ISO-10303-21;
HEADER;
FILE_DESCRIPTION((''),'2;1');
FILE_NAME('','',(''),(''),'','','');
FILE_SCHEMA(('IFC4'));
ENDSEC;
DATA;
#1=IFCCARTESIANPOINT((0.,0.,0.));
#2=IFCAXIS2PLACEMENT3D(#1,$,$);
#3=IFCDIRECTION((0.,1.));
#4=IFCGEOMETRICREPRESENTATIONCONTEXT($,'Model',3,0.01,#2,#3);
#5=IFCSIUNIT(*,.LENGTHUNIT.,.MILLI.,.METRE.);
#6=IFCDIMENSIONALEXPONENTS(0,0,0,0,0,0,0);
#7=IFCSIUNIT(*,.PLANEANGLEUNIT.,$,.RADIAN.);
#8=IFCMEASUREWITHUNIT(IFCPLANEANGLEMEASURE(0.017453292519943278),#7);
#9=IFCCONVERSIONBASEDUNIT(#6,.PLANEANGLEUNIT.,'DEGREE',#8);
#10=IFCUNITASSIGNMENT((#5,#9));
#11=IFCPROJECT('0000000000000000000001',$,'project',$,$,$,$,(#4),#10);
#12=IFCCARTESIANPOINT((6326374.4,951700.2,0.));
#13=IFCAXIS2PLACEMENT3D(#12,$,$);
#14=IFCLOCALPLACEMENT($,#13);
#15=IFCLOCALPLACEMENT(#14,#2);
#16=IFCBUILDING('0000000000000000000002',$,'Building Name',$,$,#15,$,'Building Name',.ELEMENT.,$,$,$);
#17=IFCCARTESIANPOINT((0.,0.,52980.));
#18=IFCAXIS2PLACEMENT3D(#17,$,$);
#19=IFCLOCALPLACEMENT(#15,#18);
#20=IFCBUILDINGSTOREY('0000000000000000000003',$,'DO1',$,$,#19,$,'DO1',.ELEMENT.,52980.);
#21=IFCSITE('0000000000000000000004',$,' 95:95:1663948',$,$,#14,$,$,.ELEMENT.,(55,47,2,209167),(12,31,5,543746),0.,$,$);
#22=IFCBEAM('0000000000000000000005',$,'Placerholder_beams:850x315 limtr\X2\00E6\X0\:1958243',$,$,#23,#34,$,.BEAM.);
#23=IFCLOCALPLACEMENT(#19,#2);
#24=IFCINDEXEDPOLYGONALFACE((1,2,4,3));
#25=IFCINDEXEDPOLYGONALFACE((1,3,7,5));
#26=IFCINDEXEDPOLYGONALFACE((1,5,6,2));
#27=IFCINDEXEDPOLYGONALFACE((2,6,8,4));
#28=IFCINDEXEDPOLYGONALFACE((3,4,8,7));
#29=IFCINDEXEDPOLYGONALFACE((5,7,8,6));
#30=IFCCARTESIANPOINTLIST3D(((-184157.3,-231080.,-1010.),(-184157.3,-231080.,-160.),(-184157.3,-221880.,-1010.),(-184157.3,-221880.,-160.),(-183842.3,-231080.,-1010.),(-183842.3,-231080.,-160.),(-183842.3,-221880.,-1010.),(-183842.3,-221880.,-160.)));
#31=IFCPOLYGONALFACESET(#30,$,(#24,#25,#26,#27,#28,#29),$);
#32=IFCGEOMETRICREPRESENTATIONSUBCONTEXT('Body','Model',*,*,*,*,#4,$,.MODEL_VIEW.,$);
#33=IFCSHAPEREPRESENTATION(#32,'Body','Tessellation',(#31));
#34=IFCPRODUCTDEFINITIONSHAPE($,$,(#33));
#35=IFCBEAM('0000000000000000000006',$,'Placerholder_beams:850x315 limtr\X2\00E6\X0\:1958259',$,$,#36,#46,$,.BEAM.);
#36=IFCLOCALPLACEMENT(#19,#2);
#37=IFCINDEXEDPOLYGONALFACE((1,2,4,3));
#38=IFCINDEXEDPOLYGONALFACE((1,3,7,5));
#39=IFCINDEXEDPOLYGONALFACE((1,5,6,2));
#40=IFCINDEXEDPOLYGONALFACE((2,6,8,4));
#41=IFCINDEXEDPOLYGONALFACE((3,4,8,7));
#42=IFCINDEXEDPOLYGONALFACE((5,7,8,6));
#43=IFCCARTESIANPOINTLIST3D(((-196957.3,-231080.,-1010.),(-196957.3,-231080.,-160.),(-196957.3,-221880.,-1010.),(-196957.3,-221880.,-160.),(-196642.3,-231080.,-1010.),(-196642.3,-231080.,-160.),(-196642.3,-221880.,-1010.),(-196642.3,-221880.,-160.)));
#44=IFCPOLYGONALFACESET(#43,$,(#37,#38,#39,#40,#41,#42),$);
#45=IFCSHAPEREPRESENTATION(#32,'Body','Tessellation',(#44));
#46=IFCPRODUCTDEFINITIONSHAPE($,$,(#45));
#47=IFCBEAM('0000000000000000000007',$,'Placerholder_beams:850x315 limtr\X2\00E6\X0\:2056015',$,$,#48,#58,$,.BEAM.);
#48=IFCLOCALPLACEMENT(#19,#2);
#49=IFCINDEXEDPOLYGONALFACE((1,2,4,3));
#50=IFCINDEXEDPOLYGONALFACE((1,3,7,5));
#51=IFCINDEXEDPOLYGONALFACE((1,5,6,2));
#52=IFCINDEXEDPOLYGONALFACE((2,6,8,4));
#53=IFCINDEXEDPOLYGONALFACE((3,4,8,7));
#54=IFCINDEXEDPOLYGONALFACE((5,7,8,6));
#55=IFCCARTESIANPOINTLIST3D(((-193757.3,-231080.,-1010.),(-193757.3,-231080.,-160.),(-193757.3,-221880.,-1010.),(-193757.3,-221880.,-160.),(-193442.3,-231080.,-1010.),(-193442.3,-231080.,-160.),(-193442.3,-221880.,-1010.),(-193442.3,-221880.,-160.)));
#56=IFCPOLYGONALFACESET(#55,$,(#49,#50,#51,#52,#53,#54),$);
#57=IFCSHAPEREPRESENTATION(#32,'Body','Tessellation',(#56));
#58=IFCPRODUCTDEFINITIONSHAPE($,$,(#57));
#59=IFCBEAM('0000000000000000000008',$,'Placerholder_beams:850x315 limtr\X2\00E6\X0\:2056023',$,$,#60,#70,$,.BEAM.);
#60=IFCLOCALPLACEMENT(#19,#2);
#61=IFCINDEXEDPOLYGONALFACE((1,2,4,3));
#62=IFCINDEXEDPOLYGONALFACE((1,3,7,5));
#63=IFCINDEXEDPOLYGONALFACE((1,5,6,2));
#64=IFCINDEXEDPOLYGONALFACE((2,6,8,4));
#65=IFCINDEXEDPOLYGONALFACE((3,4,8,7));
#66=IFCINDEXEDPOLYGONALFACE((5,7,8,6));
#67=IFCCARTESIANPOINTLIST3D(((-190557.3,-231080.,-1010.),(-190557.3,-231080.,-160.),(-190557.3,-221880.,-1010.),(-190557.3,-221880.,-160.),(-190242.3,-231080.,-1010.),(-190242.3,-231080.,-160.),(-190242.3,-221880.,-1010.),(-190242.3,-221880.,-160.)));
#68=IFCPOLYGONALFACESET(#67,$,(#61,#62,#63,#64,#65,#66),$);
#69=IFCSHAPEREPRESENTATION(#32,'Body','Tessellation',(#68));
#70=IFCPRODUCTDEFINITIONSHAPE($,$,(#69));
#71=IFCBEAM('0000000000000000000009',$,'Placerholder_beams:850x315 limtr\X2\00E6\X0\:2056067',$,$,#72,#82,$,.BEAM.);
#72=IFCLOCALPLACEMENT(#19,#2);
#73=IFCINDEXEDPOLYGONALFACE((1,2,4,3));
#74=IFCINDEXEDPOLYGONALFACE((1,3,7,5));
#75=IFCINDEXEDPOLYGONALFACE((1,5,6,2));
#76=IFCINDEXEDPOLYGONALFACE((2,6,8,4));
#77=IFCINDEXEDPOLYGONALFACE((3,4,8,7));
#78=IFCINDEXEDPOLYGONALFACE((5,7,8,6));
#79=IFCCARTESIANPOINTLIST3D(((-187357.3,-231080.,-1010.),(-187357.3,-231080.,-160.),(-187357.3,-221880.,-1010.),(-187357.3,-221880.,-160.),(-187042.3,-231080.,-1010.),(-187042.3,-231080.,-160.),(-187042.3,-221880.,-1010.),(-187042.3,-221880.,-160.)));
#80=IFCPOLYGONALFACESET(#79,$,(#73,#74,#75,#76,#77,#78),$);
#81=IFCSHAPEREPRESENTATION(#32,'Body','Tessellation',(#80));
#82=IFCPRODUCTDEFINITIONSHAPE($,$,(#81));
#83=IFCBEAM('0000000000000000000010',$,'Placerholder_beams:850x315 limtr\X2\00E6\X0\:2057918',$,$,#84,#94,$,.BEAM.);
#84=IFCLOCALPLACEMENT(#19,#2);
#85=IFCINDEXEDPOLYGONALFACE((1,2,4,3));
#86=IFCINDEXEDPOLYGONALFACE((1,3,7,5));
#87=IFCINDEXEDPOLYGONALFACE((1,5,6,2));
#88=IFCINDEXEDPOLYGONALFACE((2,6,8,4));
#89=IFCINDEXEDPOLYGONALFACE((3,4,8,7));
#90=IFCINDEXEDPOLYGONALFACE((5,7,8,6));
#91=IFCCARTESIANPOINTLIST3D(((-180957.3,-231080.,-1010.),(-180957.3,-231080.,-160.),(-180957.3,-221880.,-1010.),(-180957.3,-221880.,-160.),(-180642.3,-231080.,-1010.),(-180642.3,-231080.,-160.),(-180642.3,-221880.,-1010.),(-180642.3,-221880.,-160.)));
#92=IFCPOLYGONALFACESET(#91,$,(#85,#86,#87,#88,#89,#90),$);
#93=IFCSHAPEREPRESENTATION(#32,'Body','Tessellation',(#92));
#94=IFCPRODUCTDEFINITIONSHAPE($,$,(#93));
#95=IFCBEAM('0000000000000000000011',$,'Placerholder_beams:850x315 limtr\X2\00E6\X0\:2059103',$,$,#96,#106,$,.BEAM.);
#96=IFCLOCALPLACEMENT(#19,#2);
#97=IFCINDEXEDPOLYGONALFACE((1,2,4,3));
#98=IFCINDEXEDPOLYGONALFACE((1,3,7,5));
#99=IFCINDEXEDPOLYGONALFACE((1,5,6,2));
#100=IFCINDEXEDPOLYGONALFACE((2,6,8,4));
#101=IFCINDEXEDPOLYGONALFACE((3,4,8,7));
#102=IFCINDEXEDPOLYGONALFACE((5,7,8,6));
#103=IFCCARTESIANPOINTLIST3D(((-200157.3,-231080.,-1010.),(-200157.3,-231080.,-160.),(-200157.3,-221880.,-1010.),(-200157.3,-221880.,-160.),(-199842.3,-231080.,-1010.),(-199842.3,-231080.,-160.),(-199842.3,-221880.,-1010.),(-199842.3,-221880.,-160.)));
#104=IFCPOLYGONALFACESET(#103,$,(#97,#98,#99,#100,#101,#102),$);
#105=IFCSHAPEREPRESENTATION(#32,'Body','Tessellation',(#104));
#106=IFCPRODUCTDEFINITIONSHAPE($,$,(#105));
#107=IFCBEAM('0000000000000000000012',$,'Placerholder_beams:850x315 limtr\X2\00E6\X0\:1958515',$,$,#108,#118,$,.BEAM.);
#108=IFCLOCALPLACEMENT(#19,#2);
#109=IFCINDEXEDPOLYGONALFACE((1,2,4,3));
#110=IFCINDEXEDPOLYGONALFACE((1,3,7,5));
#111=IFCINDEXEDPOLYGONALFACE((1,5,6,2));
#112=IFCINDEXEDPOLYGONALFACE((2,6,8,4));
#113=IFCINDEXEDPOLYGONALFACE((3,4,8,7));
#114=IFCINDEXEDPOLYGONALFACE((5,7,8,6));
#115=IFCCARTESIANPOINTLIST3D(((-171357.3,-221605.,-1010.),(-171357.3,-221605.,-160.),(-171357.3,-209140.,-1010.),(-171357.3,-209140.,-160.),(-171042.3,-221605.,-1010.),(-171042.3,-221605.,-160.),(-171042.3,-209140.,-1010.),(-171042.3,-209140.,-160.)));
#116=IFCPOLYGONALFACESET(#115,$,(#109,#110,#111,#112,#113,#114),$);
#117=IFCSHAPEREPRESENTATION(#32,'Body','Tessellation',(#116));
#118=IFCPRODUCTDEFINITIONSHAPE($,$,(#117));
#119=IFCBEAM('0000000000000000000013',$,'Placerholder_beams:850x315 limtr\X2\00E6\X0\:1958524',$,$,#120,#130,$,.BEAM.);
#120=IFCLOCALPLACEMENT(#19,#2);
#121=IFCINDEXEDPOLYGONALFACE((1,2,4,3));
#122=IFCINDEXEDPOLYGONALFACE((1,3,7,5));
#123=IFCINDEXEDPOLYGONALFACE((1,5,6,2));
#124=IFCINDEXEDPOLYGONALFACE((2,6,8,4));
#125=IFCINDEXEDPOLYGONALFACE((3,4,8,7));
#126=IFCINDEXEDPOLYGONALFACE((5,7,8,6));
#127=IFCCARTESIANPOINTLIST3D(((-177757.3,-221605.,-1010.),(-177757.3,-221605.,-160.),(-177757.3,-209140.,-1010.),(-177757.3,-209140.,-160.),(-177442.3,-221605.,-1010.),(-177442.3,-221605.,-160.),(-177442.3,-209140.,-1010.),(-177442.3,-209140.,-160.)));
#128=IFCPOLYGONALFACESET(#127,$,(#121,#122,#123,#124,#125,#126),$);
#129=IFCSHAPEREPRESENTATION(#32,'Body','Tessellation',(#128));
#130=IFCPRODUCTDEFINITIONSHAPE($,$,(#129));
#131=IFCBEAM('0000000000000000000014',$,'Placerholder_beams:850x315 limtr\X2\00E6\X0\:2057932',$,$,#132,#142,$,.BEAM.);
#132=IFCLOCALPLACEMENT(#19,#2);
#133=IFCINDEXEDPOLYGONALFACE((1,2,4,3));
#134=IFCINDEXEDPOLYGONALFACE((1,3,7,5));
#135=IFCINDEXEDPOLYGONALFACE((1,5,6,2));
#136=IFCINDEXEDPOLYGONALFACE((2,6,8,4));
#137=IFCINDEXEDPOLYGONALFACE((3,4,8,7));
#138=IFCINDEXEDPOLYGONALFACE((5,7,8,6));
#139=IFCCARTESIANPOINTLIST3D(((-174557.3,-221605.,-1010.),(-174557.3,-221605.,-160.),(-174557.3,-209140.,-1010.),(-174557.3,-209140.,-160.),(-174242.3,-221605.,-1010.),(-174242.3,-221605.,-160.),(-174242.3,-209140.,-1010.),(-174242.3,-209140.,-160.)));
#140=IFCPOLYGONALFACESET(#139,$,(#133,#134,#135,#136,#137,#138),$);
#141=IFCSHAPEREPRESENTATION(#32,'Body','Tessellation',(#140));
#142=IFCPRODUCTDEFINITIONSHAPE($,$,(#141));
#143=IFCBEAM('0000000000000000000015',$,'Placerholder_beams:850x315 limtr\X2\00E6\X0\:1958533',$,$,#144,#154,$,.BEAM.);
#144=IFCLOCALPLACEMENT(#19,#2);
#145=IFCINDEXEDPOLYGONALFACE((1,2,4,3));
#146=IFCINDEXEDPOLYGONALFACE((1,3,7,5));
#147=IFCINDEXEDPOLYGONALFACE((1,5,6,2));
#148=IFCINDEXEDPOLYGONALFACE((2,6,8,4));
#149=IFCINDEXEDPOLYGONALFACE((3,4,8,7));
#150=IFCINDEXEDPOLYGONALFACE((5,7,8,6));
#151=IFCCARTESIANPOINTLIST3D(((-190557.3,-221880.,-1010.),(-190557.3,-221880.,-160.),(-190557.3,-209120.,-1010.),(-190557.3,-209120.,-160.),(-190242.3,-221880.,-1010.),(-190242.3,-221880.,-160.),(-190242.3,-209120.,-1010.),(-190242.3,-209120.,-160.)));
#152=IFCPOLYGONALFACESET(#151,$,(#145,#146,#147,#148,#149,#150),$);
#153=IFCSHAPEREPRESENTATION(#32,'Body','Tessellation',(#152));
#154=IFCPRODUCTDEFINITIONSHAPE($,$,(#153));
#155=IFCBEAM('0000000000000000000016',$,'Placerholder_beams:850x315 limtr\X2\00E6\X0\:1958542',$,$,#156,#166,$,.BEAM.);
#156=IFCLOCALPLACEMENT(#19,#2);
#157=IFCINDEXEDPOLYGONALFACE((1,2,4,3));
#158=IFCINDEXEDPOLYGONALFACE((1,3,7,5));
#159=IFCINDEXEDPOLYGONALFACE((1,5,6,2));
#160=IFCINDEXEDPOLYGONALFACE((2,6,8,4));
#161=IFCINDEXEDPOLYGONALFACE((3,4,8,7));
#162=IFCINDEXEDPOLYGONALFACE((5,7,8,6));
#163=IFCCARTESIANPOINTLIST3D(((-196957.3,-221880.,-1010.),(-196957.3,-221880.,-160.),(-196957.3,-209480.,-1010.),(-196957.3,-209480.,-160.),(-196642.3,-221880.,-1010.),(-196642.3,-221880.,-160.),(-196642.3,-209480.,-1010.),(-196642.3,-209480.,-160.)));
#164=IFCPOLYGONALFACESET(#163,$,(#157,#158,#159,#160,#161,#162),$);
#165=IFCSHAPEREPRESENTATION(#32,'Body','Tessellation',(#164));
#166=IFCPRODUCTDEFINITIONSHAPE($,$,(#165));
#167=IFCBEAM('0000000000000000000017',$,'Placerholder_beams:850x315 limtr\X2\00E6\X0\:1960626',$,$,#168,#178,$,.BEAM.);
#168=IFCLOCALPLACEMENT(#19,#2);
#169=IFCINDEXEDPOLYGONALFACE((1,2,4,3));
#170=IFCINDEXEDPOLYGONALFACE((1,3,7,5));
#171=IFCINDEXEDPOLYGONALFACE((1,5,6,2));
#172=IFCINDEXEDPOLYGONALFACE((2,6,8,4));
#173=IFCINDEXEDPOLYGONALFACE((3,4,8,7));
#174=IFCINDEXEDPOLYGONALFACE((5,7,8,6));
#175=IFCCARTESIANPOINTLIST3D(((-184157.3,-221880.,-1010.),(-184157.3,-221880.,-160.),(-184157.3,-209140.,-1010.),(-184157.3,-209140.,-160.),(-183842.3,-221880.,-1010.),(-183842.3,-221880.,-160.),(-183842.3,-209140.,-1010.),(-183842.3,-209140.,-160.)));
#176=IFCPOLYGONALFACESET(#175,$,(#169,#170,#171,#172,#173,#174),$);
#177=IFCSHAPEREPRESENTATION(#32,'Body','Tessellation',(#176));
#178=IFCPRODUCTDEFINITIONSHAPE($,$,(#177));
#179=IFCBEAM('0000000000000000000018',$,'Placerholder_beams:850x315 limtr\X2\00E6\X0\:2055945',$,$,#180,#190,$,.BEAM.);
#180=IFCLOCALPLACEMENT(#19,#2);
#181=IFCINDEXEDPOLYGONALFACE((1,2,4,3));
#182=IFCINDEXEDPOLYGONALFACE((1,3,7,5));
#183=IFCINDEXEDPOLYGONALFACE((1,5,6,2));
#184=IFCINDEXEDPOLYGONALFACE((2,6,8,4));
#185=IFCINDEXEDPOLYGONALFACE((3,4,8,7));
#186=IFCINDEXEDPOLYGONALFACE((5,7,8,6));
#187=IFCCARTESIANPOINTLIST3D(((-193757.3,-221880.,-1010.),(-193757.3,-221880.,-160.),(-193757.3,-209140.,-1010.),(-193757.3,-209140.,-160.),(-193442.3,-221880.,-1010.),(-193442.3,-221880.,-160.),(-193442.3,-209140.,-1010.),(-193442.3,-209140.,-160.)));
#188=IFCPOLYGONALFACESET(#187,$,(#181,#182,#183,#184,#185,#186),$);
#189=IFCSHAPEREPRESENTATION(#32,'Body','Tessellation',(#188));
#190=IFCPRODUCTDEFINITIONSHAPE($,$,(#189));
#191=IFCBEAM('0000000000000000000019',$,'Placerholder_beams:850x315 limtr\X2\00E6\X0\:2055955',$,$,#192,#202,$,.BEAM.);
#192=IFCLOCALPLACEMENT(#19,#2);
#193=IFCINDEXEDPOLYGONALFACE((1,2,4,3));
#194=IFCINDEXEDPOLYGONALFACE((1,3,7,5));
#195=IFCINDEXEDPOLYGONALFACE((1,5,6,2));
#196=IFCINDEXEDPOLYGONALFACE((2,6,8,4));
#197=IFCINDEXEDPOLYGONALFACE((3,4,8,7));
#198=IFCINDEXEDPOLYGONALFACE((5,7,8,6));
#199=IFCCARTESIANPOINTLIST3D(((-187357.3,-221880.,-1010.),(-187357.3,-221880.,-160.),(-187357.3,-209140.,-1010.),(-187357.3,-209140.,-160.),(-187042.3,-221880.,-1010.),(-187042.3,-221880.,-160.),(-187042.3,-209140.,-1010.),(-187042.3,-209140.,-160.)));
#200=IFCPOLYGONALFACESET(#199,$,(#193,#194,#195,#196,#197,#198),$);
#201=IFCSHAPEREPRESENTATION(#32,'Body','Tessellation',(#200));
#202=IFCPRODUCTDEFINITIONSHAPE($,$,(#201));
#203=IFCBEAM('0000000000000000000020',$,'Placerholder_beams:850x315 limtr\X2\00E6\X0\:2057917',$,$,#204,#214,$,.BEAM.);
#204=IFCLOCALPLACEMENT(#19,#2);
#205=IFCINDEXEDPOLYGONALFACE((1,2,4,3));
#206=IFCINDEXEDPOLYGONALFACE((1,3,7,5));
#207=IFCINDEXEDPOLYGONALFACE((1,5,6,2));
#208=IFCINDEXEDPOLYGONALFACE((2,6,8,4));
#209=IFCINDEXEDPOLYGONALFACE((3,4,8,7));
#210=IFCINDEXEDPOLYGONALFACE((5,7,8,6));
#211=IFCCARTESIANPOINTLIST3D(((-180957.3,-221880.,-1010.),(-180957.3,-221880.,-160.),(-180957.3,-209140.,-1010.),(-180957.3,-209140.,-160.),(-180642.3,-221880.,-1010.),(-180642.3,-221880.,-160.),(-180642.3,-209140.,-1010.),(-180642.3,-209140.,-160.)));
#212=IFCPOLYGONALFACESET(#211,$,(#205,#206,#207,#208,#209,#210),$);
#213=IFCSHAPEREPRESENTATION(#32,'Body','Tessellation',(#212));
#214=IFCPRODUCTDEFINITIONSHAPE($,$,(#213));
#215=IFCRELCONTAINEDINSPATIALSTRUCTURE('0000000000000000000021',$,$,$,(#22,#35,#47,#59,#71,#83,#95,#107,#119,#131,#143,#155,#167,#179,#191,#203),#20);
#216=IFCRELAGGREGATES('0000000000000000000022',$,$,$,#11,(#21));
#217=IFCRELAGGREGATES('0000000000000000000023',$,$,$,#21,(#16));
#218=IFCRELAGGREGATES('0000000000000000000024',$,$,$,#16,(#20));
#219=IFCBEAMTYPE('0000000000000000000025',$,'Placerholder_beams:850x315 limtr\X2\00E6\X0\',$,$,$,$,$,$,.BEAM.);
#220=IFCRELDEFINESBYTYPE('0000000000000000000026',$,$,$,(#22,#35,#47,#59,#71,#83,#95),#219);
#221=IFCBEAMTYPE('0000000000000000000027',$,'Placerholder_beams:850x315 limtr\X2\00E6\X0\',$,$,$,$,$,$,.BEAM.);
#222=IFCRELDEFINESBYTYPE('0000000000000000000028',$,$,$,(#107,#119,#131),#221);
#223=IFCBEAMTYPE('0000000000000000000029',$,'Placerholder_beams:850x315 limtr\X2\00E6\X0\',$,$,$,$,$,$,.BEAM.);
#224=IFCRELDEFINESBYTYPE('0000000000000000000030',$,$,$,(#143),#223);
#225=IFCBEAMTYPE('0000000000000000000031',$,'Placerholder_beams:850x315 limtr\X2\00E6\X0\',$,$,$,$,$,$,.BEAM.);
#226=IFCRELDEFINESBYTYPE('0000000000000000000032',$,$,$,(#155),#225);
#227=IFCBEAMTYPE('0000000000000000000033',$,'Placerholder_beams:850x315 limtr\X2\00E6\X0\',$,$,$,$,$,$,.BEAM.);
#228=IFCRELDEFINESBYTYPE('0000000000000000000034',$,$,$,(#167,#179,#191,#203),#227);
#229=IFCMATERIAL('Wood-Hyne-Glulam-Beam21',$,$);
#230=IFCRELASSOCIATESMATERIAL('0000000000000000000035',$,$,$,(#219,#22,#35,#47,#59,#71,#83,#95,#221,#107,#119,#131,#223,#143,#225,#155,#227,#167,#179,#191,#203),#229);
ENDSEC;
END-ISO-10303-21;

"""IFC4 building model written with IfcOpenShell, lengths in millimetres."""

from ifc_helpers import new_model, entity, si_unit, converted_unit, direction, frame, origin, place, context, subcontext, project, spatial, indexed_curve, outline, extrude, source, transform, mapped, material, type_object, type_shapes, element, save


model = new_model("IFC4")

# Units and contexts
model_context = context("Model", 3, precision=0.01, world=origin(), true_north=direction((0.0, 1.0)))
body_context = subcontext(model_context, "Body", "Model", "MODEL_VIEW")
ifc_project = project(units=[si_unit("LENGTHUNIT", "METRE", prefix="MILLI"), converted_unit("PLANEANGLEUNIT", "DEGREE", entity("IfcPlaneAngleMeasure", 0.017453292519943278), si_unit("PLANEANGLEUNIT", "RADIAN"), dimensions=[0, 0, 0, 0, 0, 0, 0])], contexts=[model_context])

# Site, building, storey
site_placement = place(None, frame((6326374.4, 951700.2, 0.0)))
site = spatial("IfcSite", under=ifc_project, at=site_placement, Name=" 95:95:1663948", CompositionType="ELEMENT", RefLatitude=(55, 47, 2, 209167), RefLongitude=(12, 31, 5, 543746), RefElevation=0.0)
building_placement = place(site_placement, origin())
building = spatial("IfcBuilding", under=site, at=building_placement, Name="Building Name", LongName="Building Name", CompositionType="ELEMENT")
storey_placement = place(building_placement, frame((0.0, 0.0, 52980.0)))
storey = spatial("IfcBuildingStorey", under=building, at=storey_placement, Name="DO1", LongName="DO1", CompositionType="ELEMENT", Elevation=52980.0)

# Beams
ifc_material = material(Name="Wood-Hyne-Glulam-Beam21")
beam_type_1 = type_object("IfcBeamType", Name="Placerholder_beams:850x315 limtræ", PredefinedType="BEAM", material=ifc_material)
shared_shape_1 = source(origin(), body_context, "Body", "SweptSolid", [
    extrude(outline(indexed_curve([(-4600.0, -157.5), (4600.0, -157.5), (4600.0, 157.5), (-4600.0, 157.5), (-4600.0, -157.5)], self_intersect=False)), frame((0.0, 0.0, -425.0)), (0.0, 0.0, 1.0), 850.0),
])
type_shapes(beam_type_1, [shared_shape_1])
for number, where, z_axis, x_axis, name in (
    (1, (-183999.8, -226480.0, -585.0), (0.0, 0.0, 1.0), (0.0, 1.0, 0.0), "Placerholder_beams:850x315 limtræ:1958243"),
    (2, (-196799.8, -226480.0, -585.0), (0.0, 0.0, 1.0), (0.0, 1.0, 0.0), "Placerholder_beams:850x315 limtræ:1958259"),
    (3, (-193599.8, -226480.0, -585.0), (0.0, 0.0, 1.0), (0.0, 1.0, 0.0), "Placerholder_beams:850x315 limtræ:2056015"),
    (4, (-190399.8, -226480.0, -585.0), (0.0, 0.0, 1.0), (0.0, 1.0, 0.0), "Placerholder_beams:850x315 limtræ:2056023"),
    (5, (-187199.8, -226480.0, -585.0), (0.0, 0.0, 1.0), (0.0, 1.0, 0.0), "Placerholder_beams:850x315 limtræ:2056067"),
    (6, (-180799.8, -226480.0, -585.0), (0.0, 0.0, 1.0), (0.0, 1.0, 0.0), "Placerholder_beams:850x315 limtræ:2057918"),
    (7, (-199999.8, -226480.0, -585.0), (0.0, 0.0, 1.0), (0.0, 1.0, 0.0), "Placerholder_beams:850x315 limtræ:2059103"),
):
    element("IfcBeam", number, at=place(storey_placement, frame(where, z_axis=z_axis, x_axis=x_axis)), inside=storey, type_object=beam_type_1, material=ifc_material, Name=name, PredefinedType="BEAM", context=body_context, shape_type="MappedRepresentation", body=[
        mapped(shared_shape_1, transform((0.0, 0.0, 0.0), scale=1.0)),
    ])
beam_type_2 = type_object("IfcBeamType", Name="Placerholder_beams:850x315 limtræ", PredefinedType="BEAM", material=ifc_material)
shared_shape_2 = source(origin(), body_context, "Body", "SweptSolid", [
    extrude(outline(indexed_curve([(-6232.5, -157.5), (6232.5, -157.5), (6232.5, 157.5), (-6232.5, 157.5), (-6232.5, -157.5)], self_intersect=False)), frame((247.5, 0.0, -425.0)), (0.0, 0.0, 1.0), 850.0),
])
type_shapes(beam_type_2, [shared_shape_2])
for number, where, z_axis, x_axis, name in (
    (8, (-171199.8, -215620.0, -585.0), (0.0, 0.0, 1.0), (0.0, 1.0, 0.0), "Placerholder_beams:850x315 limtræ:1958515"),
    (9, (-177599.8, -215620.0, -585.0), (0.0, 0.0, 1.0), (0.0, 1.0, 0.0), "Placerholder_beams:850x315 limtræ:1958524"),
    (10, (-174399.8, -215620.0, -585.0), (0.0, 0.0, 1.0), (0.0, 1.0, 0.0), "Placerholder_beams:850x315 limtræ:2057932"),
):
    element("IfcBeam", number, at=place(storey_placement, frame(where, z_axis=z_axis, x_axis=x_axis)), inside=storey, type_object=beam_type_2, material=ifc_material, Name=name, PredefinedType="BEAM", context=body_context, shape_type="MappedRepresentation", body=[
        mapped(shared_shape_2, transform((0.0, 0.0, 0.0), scale=1.0)),
    ])
beam_type_3 = type_object("IfcBeamType", Name="Placerholder_beams:850x315 limtræ", PredefinedType="BEAM", material=ifc_material)
shared_shape_3 = source(origin(), body_context, "Body", "SweptSolid", [
    extrude(outline(indexed_curve([(-6380.0, -157.5), (6380.0, -157.5), (6380.0, 157.5), (-6380.0, 157.5), (-6380.0, -157.5)], self_intersect=False)), frame((20.0, 0.0, -425.0)), (0.0, 0.0, 1.0), 850.0),
])
type_shapes(beam_type_3, [shared_shape_3])
beam_1_placement = place(storey_placement, frame((-190399.8, -215520.0, -585.0), z_axis=(0.0, 0.0, 1.0), x_axis=(0.0, 1.0, 0.0)))
element("IfcBeam", 11, at=beam_1_placement, inside=storey, type_object=beam_type_3, material=ifc_material, Name="Placerholder_beams:850x315 limtræ:1958533", PredefinedType="BEAM", context=body_context, shape_type="MappedRepresentation", body=[
    mapped(shared_shape_3, transform((0.0, 0.0, 0.0), scale=1.0)),
])
beam_type_4 = type_object("IfcBeamType", Name="Placerholder_beams:850x315 limtræ", PredefinedType="BEAM", material=ifc_material)
shared_shape_4 = source(origin(), body_context, "Body", "SweptSolid", [
    extrude(outline(indexed_curve([(-6200.0, -157.5), (6200.0, -157.5), (6200.0, 157.5), (-6200.0, 157.5), (-6200.0, -157.5)], self_intersect=False)), frame((-60.0, 0.0, -425.0)), (0.0, 0.0, 1.0), 850.0),
])
type_shapes(beam_type_4, [shared_shape_4])
beam_2_placement = place(storey_placement, frame((-196799.8, -215620.0, -585.0), z_axis=(0.0, 0.0, 1.0), x_axis=(0.0, 1.0, 0.0)))
element("IfcBeam", 12, at=beam_2_placement, inside=storey, type_object=beam_type_4, material=ifc_material, Name="Placerholder_beams:850x315 limtræ:1958542", PredefinedType="BEAM", context=body_context, shape_type="MappedRepresentation", body=[
    mapped(shared_shape_4, transform((0.0, 0.0, 0.0), scale=1.0)),
])
beam_type_5 = type_object("IfcBeamType", Name="Placerholder_beams:850x315 limtræ", PredefinedType="BEAM", material=ifc_material)
shared_shape_5 = source(origin(), body_context, "Body", "SweptSolid", [
    extrude(outline(indexed_curve([(-6370.0, -157.5), (6370.0, -157.5), (6370.0, 157.5), (-6370.0, 157.5), (-6370.0, -157.5)], self_intersect=False)), frame((110.0, 0.0, -425.0)), (0.0, 0.0, 1.0), 850.0),
])
type_shapes(beam_type_5, [shared_shape_5])
for number, where, z_axis, x_axis, name in (
    (13, (-183999.8, -215620.0, -585.0), (0.0, 0.0, 1.0), (0.0, 1.0, 0.0), "Placerholder_beams:850x315 limtræ:1960626"),
    (14, (-193599.8, -215620.0, -585.0), (0.0, 0.0, 1.0), (0.0, 1.0, 0.0), "Placerholder_beams:850x315 limtræ:2055945"),
    (15, (-187199.8, -215620.0, -585.0), (0.0, 0.0, 1.0), (0.0, 1.0, 0.0), "Placerholder_beams:850x315 limtræ:2055955"),
    (16, (-180799.8, -215620.0, -585.0), (0.0, 0.0, 1.0), (0.0, 1.0, 0.0), "Placerholder_beams:850x315 limtræ:2057917"),
):
    element("IfcBeam", number, at=place(storey_placement, frame(where, z_axis=z_axis, x_axis=x_axis)), inside=storey, type_object=beam_type_5, material=ifc_material, Name=name, PredefinedType="BEAM", context=body_context, shape_type="MappedRepresentation", body=[
        mapped(shared_shape_5, transform((0.0, 0.0, 0.0), scale=1.0)),
    ])

save(model, "model.ifc")
